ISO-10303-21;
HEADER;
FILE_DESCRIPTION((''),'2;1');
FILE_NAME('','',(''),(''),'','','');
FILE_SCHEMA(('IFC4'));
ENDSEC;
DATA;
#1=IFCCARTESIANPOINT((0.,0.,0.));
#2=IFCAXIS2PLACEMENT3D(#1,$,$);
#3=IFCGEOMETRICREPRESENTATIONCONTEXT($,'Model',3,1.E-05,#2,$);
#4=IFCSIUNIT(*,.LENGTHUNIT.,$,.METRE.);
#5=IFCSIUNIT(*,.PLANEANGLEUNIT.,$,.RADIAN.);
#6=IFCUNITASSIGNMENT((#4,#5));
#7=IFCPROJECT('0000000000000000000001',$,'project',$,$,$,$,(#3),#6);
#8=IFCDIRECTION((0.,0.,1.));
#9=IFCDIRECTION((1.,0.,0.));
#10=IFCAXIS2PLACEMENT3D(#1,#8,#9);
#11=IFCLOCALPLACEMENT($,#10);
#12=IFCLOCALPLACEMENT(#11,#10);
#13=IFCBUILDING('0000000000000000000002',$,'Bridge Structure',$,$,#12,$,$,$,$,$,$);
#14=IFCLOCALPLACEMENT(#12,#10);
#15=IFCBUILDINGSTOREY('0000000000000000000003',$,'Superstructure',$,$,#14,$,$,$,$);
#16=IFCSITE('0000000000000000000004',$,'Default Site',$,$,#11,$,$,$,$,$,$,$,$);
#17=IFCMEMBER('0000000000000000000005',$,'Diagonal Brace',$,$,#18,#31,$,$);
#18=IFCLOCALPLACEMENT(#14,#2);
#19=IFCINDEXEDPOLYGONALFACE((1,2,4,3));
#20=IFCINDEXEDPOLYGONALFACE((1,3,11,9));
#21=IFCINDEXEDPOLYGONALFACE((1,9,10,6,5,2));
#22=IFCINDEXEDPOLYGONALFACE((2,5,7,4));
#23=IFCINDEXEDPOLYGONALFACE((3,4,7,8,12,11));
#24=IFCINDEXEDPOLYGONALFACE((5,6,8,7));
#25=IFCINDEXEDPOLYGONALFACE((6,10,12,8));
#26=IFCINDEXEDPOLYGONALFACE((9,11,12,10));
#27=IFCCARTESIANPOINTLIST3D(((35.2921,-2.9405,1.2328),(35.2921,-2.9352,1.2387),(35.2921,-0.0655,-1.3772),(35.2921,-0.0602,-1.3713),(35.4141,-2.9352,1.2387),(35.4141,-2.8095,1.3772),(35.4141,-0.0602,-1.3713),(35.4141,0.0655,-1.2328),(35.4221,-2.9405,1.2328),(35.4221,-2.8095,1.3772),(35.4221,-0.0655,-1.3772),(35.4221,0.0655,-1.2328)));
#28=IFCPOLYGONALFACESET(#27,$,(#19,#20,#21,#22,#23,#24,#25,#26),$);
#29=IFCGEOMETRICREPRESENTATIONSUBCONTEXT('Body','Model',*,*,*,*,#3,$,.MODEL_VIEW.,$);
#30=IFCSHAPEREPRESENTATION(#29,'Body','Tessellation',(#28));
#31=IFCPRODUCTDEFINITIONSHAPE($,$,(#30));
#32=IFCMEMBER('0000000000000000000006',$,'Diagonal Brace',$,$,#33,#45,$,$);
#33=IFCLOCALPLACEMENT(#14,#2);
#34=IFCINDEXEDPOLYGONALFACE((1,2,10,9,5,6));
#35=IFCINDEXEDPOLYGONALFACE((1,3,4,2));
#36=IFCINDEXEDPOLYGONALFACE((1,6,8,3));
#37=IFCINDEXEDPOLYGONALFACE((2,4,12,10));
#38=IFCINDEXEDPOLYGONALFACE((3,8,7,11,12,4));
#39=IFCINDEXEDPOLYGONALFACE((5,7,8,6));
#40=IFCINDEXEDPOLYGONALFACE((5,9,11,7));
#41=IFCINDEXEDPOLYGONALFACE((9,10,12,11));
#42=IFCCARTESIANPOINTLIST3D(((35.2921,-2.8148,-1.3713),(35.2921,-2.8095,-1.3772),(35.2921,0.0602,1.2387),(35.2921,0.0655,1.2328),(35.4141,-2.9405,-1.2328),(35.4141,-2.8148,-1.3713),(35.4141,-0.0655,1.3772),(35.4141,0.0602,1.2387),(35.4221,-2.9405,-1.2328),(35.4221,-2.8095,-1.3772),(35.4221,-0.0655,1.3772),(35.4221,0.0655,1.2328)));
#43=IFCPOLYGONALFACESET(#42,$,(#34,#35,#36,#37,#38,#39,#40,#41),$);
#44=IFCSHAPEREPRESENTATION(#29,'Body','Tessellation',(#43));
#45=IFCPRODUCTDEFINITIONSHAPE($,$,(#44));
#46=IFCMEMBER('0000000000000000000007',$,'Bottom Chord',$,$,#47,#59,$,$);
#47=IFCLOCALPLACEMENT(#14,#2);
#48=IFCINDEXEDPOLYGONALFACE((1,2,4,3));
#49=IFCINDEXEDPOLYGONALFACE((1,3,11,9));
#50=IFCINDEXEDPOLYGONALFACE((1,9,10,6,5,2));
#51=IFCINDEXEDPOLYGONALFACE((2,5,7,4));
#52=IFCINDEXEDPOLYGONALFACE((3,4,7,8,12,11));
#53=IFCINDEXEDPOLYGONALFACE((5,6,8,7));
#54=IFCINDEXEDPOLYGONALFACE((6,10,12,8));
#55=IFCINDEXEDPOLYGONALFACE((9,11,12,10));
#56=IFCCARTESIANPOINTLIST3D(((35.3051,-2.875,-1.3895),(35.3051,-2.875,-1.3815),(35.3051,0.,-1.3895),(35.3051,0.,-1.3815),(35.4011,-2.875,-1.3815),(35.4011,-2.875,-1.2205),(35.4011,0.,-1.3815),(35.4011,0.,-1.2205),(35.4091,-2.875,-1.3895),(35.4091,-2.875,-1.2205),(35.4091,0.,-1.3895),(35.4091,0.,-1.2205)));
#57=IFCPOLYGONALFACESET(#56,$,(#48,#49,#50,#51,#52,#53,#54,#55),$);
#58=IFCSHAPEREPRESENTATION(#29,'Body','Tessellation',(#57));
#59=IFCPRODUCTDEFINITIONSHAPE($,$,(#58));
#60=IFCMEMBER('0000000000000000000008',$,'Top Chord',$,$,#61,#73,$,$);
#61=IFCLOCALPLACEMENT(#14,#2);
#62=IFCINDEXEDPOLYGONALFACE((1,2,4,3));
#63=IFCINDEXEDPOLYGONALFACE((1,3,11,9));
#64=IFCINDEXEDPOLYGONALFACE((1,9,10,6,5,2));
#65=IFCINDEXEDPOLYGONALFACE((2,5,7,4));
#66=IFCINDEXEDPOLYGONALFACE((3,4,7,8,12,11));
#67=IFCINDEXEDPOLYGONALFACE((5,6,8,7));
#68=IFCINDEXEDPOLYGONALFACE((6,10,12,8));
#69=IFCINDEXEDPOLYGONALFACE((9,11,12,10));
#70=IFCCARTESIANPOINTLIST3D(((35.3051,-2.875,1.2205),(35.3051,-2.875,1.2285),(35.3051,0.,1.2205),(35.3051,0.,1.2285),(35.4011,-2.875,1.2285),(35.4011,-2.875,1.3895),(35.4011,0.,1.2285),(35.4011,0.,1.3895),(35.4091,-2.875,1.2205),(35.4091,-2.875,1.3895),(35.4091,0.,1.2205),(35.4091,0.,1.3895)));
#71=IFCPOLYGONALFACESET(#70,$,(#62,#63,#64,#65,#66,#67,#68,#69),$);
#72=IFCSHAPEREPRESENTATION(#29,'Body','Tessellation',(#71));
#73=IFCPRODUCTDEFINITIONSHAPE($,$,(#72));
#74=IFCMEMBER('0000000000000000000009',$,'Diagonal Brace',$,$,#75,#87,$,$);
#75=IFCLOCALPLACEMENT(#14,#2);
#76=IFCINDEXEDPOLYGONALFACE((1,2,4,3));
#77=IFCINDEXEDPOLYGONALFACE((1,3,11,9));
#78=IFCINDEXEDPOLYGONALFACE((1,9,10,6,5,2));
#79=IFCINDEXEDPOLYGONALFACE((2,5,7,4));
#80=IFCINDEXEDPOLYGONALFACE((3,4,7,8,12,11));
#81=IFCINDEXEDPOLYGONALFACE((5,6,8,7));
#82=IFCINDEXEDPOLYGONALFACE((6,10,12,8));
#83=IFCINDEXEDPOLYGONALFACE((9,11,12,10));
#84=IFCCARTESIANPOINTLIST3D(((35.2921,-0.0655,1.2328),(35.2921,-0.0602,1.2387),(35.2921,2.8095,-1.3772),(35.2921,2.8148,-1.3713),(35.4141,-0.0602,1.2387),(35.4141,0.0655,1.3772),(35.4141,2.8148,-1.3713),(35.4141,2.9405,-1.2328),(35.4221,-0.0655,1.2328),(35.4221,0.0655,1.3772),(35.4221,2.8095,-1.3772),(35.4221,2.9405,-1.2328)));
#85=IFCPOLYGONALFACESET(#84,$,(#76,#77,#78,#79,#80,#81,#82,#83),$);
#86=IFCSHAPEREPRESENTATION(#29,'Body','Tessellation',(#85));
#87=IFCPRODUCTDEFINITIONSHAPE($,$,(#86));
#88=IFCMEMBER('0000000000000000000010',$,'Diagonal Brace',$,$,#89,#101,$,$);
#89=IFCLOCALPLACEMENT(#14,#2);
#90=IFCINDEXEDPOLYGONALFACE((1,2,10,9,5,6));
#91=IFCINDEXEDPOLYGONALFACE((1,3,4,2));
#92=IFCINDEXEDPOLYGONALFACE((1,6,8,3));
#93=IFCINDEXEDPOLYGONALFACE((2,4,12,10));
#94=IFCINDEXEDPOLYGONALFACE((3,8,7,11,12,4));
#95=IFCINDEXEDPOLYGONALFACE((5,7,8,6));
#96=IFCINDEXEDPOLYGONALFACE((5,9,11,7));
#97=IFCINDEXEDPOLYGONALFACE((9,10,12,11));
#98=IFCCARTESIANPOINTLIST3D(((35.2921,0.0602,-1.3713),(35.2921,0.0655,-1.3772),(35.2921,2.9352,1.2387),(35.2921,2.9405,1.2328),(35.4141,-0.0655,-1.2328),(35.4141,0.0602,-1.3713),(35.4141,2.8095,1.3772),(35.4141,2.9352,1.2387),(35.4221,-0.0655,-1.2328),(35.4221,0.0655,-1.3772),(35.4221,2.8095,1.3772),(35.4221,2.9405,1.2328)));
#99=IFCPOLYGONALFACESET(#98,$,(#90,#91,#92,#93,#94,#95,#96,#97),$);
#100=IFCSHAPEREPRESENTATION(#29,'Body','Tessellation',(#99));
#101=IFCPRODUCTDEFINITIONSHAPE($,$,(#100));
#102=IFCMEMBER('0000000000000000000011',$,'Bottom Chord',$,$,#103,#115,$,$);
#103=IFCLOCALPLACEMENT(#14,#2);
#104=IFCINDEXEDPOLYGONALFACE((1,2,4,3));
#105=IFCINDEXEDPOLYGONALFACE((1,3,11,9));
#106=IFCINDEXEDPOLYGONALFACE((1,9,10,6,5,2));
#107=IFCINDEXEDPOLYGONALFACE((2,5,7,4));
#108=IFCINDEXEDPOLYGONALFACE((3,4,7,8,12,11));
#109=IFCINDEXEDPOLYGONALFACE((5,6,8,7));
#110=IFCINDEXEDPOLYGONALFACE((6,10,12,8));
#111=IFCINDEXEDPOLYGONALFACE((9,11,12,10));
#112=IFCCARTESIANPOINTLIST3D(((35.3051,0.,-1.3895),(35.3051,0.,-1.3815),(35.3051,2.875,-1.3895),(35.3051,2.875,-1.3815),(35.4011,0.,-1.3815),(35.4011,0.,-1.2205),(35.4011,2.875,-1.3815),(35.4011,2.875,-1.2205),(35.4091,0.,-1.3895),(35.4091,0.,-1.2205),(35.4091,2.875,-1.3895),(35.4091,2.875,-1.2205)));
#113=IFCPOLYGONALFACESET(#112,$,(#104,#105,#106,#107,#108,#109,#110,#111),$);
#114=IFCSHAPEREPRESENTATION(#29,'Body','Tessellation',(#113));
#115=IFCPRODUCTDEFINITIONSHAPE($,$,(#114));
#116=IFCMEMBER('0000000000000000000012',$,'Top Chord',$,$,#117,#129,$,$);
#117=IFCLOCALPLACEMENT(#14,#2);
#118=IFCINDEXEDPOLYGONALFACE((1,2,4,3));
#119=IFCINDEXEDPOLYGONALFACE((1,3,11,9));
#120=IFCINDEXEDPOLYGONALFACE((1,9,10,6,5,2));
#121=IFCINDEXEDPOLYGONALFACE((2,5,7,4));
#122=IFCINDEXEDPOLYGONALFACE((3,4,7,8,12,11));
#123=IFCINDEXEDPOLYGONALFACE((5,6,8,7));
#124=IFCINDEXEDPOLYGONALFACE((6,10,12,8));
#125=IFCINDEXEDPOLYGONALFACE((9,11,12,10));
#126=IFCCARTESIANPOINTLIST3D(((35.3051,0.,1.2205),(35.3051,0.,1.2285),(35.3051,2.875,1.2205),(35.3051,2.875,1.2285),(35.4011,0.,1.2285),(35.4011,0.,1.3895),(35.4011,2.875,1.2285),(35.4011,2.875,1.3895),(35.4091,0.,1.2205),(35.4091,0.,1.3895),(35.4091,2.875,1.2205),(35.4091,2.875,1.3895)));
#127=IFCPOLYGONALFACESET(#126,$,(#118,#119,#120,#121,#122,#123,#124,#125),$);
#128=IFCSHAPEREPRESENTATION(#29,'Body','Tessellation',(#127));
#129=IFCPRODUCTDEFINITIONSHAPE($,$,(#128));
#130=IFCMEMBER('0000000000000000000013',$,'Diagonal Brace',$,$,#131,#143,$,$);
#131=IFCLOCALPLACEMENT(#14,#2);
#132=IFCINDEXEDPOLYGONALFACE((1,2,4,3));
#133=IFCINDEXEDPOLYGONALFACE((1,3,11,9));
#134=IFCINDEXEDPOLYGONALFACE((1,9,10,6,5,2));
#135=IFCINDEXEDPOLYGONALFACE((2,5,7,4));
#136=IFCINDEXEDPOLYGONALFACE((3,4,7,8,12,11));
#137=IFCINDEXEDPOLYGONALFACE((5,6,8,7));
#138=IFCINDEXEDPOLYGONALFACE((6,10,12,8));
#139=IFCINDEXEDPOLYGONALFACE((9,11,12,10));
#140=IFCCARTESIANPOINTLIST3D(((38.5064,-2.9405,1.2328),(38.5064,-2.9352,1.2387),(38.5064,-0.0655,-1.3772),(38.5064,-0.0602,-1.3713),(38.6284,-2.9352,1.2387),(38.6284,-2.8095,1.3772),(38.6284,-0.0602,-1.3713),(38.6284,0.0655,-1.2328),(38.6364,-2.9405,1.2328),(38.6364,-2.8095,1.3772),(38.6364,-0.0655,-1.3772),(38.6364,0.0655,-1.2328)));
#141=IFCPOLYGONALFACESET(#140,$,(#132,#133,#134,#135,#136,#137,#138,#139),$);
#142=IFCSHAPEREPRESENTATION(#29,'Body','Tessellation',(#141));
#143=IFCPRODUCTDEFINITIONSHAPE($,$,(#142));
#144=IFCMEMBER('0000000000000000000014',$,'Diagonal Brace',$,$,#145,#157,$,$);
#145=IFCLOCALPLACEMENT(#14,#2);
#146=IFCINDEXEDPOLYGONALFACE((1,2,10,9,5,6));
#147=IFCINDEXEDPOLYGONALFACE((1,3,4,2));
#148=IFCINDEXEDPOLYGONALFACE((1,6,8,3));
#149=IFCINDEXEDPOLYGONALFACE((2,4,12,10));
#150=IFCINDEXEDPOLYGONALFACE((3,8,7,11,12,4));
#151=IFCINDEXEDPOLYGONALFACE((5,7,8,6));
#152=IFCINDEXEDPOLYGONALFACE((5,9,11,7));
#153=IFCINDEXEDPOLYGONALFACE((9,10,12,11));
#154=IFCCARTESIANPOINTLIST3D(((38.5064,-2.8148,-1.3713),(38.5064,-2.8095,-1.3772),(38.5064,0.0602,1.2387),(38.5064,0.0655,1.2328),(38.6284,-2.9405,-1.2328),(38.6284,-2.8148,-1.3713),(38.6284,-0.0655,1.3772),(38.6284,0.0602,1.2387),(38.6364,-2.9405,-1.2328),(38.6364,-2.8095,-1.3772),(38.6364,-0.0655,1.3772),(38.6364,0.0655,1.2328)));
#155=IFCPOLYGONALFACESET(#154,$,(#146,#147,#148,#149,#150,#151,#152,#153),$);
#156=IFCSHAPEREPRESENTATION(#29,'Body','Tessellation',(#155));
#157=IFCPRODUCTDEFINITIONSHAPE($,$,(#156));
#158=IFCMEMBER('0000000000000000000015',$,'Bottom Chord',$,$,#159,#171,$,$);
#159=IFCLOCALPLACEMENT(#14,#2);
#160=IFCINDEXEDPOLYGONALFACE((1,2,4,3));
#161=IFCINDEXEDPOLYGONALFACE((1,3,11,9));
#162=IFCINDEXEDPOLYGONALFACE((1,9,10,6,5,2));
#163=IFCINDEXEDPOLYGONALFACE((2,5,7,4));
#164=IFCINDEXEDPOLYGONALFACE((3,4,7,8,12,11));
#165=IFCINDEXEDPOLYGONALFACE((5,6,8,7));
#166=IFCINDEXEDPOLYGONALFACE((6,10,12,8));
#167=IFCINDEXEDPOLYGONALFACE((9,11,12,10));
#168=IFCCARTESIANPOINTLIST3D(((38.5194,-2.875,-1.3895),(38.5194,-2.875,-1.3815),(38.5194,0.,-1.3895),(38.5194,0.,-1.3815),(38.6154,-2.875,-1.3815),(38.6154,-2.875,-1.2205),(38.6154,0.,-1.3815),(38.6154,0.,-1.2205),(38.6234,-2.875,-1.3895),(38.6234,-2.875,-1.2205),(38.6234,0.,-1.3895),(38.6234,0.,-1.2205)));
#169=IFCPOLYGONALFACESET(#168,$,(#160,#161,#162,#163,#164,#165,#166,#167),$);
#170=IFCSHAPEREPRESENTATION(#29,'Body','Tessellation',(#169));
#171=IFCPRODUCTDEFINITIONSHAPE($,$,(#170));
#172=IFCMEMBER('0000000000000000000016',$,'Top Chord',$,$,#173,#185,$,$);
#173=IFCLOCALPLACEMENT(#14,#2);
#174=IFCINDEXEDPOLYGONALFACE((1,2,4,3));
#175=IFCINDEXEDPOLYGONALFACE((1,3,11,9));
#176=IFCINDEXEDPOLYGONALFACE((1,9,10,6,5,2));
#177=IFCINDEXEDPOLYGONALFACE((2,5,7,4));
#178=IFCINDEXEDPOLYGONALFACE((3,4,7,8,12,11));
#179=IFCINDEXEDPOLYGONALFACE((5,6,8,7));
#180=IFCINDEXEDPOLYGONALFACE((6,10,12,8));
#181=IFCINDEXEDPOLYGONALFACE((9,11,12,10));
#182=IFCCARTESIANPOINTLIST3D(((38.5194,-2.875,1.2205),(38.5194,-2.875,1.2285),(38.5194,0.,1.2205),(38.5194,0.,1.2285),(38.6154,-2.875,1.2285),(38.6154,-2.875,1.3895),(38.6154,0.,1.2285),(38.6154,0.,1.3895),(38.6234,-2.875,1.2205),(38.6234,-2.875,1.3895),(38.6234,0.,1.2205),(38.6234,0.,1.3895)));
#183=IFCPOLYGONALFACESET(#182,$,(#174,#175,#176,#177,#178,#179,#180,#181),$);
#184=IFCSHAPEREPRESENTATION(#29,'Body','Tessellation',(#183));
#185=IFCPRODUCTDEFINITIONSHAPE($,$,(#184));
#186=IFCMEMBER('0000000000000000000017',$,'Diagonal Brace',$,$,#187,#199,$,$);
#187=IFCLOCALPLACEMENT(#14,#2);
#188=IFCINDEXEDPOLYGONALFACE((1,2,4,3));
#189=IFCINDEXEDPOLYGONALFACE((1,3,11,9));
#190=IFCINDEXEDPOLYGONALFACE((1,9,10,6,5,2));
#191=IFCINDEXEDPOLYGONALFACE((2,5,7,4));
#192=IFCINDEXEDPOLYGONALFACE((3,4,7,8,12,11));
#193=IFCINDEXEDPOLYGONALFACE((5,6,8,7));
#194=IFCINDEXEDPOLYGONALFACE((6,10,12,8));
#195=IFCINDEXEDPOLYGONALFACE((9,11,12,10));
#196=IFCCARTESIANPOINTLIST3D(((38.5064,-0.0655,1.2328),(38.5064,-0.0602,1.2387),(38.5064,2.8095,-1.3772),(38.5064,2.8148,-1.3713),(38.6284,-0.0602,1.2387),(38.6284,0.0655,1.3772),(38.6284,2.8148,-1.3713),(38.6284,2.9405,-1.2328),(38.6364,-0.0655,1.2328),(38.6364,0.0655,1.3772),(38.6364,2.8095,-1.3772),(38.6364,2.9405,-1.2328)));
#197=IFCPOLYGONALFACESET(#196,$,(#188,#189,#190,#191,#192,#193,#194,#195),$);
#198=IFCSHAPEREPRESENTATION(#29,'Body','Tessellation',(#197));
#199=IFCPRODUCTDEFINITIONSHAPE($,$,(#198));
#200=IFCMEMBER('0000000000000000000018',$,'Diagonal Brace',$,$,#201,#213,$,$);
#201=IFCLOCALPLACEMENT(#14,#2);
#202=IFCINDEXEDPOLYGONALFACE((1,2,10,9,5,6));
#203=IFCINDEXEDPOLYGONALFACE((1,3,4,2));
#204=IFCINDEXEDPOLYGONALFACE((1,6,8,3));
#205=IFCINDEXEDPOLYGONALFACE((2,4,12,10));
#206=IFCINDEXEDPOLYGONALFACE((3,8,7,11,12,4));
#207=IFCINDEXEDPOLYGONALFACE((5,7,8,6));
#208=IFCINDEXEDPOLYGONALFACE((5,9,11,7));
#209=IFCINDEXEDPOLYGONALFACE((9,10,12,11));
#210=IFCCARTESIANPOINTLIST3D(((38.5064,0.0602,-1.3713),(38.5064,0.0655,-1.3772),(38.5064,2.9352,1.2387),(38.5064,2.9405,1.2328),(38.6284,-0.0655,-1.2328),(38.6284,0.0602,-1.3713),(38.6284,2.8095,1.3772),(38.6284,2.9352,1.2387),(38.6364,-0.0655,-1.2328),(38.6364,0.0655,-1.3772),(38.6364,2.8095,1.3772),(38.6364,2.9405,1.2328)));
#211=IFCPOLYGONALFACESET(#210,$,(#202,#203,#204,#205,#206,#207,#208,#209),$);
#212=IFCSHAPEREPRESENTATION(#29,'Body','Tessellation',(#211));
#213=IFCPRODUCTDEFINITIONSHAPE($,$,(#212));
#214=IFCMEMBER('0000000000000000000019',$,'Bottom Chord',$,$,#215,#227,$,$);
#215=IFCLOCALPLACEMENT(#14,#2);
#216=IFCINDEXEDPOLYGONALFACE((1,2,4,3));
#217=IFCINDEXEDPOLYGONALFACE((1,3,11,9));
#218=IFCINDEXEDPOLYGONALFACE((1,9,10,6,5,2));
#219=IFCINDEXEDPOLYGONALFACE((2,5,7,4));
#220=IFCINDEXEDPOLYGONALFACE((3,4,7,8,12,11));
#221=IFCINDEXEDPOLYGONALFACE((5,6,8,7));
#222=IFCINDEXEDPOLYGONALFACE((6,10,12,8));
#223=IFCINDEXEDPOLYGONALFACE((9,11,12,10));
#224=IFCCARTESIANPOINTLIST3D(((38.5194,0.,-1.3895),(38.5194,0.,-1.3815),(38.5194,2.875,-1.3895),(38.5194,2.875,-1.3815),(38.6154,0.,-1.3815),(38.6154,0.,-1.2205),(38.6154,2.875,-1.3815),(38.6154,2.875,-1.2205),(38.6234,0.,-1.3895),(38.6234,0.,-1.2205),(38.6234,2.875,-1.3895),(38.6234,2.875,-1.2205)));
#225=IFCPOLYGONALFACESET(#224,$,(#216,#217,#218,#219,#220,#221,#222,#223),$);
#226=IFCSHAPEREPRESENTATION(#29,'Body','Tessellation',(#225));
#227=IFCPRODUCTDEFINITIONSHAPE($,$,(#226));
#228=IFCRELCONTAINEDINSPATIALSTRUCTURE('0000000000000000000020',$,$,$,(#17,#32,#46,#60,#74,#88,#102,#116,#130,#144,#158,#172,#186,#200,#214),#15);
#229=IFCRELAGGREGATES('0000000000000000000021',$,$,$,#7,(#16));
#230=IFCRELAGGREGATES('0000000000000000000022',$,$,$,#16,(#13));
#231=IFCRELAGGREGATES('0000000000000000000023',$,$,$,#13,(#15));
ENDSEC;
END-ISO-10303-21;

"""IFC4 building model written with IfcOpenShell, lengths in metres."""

from ifc_helpers import new_model, si_unit, frame, origin, origin_with_axes, origin_2d_with_axis, place, context, subcontext, project, spatial, l_section, extrude, element, save


model = new_model("IFC4")

# Units and contexts
model_context = context("Model", 3, precision=1e-05, world=origin())
body_context = subcontext(model_context, "Body", "Model", "MODEL_VIEW")
ifc_project = project(units=[si_unit("LENGTHUNIT", "METRE"), si_unit("PLANEANGLEUNIT", "RADIAN")], contexts=[model_context])

# Site, building, storey
site_placement = place(None, origin_with_axes())
site = spatial("IfcSite", under=ifc_project, at=site_placement, Name="Default Site")
building_placement = place(site_placement, origin_with_axes())
building = spatial("IfcBuilding", under=site, at=building_placement, Name="Bridge Structure")
storey_placement = place(building_placement, origin_with_axes())
storey = spatial("IfcBuildingStorey", under=building, at=storey_placement, Name="Superstructure")

# Members
for number, where, z_axis, x_axis, name in (
    (1, (35.3571, -2.875, 1.305), (0.0, 0.740406, -0.67216), (-1.0, 0.0, 0.0), "Diagonal Brace"),
    (2, (35.3571, -2.875, -1.305), (0.0, 0.740406, 0.67216), (-1.0, 0.0, 0.0), "Diagonal Brace"),
):
    element("IfcMember", number, at=place(storey_placement, frame(where, z_axis=z_axis, x_axis=x_axis)), inside=storey, Name=name, context=body_context, shape_type="SweptSolid", body=[
        extrude(l_section(Depth=0.195, Width=0.13, Thickness=0.008, at=origin_2d_with_axis()), origin_with_axes(), (0.0, 0.0, 1.0), 3.883),
    ])
for number, where, z_axis, x_axis, name in (
    (3, (35.3571, -2.875, -1.305), (0.0, 1.0, 0.0), (-1.0, 0.0, 0.0), "Bottom Chord"),
    (4, (35.3571, -2.875, 1.305), (0.0, 1.0, 0.0), (-1.0, 0.0, 0.0), "Top Chord"),
):
    element("IfcMember", number, at=place(storey_placement, frame(where, z_axis=z_axis, x_axis=x_axis)), inside=storey, Name=name, context=body_context, shape_type="SweptSolid", body=[
        extrude(l_section(Depth=0.169, Width=0.104, Thickness=0.008, at=origin_2d_with_axis()), origin_with_axes(), (0.0, 0.0, 1.0), 2.875),
    ])
for number, where, z_axis, x_axis, name in (
    (5, (35.3571, 0.0, 1.305), (0.0, 0.740406, -0.67216), (-1.0, 0.0, 0.0), "Diagonal Brace"),
    (6, (35.3571, 0.0, -1.305), (0.0, 0.740406, 0.67216), (-1.0, 0.0, 0.0), "Diagonal Brace"),
):
    element("IfcMember", number, at=place(storey_placement, frame(where, z_axis=z_axis, x_axis=x_axis)), inside=storey, Name=name, context=body_context, shape_type="SweptSolid", body=[
        extrude(l_section(Depth=0.195, Width=0.13, Thickness=0.008, at=origin_2d_with_axis()), origin_with_axes(), (0.0, 0.0, 1.0), 3.883),
    ])
for number, where, z_axis, x_axis, name in (
    (7, (35.3571, 0.0, -1.305), (0.0, 1.0, 0.0), (-1.0, 0.0, 0.0), "Bottom Chord"),
    (8, (35.3571, 0.0, 1.305), (0.0, 1.0, 0.0), (-1.0, 0.0, 0.0), "Top Chord"),
):
    element("IfcMember", number, at=place(storey_placement, frame(where, z_axis=z_axis, x_axis=x_axis)), inside=storey, Name=name, context=body_context, shape_type="SweptSolid", body=[
        extrude(l_section(Depth=0.169, Width=0.104, Thickness=0.008, at=origin_2d_with_axis()), origin_with_axes(), (0.0, 0.0, 1.0), 2.875),
    ])
for number, where, z_axis, x_axis, name in (
    (9, (38.5714, -2.875, 1.305), (0.0, 0.740406, -0.67216), (-1.0, 0.0, 0.0), "Diagonal Brace"),
    (10, (38.5714, -2.875, -1.305), (0.0, 0.740406, 0.67216), (-1.0, 0.0, 0.0), "Diagonal Brace"),
):
    element("IfcMember", number, at=place(storey_placement, frame(where, z_axis=z_axis, x_axis=x_axis)), inside=storey, Name=name, context=body_context, shape_type="SweptSolid", body=[
        extrude(l_section(Depth=0.195, Width=0.13, Thickness=0.008, at=origin_2d_with_axis()), origin_with_axes(), (0.0, 0.0, 1.0), 3.883),
    ])
for number, where, z_axis, x_axis, name in (
    (11, (38.5714, -2.875, -1.305), (0.0, 1.0, 0.0), (-1.0, 0.0, 0.0), "Bottom Chord"),
    (12, (38.5714, -2.875, 1.305), (0.0, 1.0, 0.0), (-1.0, 0.0, 0.0), "Top Chord"),
):
    element("IfcMember", number, at=place(storey_placement, frame(where, z_axis=z_axis, x_axis=x_axis)), inside=storey, Name=name, context=body_context, shape_type="SweptSolid", body=[
        extrude(l_section(Depth=0.169, Width=0.104, Thickness=0.008, at=origin_2d_with_axis()), origin_with_axes(), (0.0, 0.0, 1.0), 2.875),
    ])
for number, where, z_axis, x_axis, name in (
    (13, (38.5714, 0.0, 1.305), (0.0, 0.740406, -0.67216), (-1.0, 0.0, 0.0), "Diagonal Brace"),
    (14, (38.5714, 0.0, -1.305), (0.0, 0.740406, 0.67216), (-1.0, 0.0, 0.0), "Diagonal Brace"),
):
    element("IfcMember", number, at=place(storey_placement, frame(where, z_axis=z_axis, x_axis=x_axis)), inside=storey, Name=name, context=body_context, shape_type="SweptSolid", body=[
        extrude(l_section(Depth=0.195, Width=0.13, Thickness=0.008, at=origin_2d_with_axis()), origin_with_axes(), (0.0, 0.0, 1.0), 3.883),
    ])
for number, where, z_axis, x_axis, name in (
    (15, (38.5714, 0.0, -1.305), (0.0, 1.0, 0.0), (-1.0, 0.0, 0.0), "Bottom Chord"),
):
    element("IfcMember", number, at=place(storey_placement, frame(where, z_axis=z_axis, x_axis=x_axis)), inside=storey, Name=name, context=body_context, shape_type="SweptSolid", body=[
        extrude(l_section(Depth=0.169, Width=0.104, Thickness=0.008, at=origin_2d_with_axis()), origin_with_axes(), (0.0, 0.0, 1.0), 2.875),
    ])

save(model, "model.ifc")
